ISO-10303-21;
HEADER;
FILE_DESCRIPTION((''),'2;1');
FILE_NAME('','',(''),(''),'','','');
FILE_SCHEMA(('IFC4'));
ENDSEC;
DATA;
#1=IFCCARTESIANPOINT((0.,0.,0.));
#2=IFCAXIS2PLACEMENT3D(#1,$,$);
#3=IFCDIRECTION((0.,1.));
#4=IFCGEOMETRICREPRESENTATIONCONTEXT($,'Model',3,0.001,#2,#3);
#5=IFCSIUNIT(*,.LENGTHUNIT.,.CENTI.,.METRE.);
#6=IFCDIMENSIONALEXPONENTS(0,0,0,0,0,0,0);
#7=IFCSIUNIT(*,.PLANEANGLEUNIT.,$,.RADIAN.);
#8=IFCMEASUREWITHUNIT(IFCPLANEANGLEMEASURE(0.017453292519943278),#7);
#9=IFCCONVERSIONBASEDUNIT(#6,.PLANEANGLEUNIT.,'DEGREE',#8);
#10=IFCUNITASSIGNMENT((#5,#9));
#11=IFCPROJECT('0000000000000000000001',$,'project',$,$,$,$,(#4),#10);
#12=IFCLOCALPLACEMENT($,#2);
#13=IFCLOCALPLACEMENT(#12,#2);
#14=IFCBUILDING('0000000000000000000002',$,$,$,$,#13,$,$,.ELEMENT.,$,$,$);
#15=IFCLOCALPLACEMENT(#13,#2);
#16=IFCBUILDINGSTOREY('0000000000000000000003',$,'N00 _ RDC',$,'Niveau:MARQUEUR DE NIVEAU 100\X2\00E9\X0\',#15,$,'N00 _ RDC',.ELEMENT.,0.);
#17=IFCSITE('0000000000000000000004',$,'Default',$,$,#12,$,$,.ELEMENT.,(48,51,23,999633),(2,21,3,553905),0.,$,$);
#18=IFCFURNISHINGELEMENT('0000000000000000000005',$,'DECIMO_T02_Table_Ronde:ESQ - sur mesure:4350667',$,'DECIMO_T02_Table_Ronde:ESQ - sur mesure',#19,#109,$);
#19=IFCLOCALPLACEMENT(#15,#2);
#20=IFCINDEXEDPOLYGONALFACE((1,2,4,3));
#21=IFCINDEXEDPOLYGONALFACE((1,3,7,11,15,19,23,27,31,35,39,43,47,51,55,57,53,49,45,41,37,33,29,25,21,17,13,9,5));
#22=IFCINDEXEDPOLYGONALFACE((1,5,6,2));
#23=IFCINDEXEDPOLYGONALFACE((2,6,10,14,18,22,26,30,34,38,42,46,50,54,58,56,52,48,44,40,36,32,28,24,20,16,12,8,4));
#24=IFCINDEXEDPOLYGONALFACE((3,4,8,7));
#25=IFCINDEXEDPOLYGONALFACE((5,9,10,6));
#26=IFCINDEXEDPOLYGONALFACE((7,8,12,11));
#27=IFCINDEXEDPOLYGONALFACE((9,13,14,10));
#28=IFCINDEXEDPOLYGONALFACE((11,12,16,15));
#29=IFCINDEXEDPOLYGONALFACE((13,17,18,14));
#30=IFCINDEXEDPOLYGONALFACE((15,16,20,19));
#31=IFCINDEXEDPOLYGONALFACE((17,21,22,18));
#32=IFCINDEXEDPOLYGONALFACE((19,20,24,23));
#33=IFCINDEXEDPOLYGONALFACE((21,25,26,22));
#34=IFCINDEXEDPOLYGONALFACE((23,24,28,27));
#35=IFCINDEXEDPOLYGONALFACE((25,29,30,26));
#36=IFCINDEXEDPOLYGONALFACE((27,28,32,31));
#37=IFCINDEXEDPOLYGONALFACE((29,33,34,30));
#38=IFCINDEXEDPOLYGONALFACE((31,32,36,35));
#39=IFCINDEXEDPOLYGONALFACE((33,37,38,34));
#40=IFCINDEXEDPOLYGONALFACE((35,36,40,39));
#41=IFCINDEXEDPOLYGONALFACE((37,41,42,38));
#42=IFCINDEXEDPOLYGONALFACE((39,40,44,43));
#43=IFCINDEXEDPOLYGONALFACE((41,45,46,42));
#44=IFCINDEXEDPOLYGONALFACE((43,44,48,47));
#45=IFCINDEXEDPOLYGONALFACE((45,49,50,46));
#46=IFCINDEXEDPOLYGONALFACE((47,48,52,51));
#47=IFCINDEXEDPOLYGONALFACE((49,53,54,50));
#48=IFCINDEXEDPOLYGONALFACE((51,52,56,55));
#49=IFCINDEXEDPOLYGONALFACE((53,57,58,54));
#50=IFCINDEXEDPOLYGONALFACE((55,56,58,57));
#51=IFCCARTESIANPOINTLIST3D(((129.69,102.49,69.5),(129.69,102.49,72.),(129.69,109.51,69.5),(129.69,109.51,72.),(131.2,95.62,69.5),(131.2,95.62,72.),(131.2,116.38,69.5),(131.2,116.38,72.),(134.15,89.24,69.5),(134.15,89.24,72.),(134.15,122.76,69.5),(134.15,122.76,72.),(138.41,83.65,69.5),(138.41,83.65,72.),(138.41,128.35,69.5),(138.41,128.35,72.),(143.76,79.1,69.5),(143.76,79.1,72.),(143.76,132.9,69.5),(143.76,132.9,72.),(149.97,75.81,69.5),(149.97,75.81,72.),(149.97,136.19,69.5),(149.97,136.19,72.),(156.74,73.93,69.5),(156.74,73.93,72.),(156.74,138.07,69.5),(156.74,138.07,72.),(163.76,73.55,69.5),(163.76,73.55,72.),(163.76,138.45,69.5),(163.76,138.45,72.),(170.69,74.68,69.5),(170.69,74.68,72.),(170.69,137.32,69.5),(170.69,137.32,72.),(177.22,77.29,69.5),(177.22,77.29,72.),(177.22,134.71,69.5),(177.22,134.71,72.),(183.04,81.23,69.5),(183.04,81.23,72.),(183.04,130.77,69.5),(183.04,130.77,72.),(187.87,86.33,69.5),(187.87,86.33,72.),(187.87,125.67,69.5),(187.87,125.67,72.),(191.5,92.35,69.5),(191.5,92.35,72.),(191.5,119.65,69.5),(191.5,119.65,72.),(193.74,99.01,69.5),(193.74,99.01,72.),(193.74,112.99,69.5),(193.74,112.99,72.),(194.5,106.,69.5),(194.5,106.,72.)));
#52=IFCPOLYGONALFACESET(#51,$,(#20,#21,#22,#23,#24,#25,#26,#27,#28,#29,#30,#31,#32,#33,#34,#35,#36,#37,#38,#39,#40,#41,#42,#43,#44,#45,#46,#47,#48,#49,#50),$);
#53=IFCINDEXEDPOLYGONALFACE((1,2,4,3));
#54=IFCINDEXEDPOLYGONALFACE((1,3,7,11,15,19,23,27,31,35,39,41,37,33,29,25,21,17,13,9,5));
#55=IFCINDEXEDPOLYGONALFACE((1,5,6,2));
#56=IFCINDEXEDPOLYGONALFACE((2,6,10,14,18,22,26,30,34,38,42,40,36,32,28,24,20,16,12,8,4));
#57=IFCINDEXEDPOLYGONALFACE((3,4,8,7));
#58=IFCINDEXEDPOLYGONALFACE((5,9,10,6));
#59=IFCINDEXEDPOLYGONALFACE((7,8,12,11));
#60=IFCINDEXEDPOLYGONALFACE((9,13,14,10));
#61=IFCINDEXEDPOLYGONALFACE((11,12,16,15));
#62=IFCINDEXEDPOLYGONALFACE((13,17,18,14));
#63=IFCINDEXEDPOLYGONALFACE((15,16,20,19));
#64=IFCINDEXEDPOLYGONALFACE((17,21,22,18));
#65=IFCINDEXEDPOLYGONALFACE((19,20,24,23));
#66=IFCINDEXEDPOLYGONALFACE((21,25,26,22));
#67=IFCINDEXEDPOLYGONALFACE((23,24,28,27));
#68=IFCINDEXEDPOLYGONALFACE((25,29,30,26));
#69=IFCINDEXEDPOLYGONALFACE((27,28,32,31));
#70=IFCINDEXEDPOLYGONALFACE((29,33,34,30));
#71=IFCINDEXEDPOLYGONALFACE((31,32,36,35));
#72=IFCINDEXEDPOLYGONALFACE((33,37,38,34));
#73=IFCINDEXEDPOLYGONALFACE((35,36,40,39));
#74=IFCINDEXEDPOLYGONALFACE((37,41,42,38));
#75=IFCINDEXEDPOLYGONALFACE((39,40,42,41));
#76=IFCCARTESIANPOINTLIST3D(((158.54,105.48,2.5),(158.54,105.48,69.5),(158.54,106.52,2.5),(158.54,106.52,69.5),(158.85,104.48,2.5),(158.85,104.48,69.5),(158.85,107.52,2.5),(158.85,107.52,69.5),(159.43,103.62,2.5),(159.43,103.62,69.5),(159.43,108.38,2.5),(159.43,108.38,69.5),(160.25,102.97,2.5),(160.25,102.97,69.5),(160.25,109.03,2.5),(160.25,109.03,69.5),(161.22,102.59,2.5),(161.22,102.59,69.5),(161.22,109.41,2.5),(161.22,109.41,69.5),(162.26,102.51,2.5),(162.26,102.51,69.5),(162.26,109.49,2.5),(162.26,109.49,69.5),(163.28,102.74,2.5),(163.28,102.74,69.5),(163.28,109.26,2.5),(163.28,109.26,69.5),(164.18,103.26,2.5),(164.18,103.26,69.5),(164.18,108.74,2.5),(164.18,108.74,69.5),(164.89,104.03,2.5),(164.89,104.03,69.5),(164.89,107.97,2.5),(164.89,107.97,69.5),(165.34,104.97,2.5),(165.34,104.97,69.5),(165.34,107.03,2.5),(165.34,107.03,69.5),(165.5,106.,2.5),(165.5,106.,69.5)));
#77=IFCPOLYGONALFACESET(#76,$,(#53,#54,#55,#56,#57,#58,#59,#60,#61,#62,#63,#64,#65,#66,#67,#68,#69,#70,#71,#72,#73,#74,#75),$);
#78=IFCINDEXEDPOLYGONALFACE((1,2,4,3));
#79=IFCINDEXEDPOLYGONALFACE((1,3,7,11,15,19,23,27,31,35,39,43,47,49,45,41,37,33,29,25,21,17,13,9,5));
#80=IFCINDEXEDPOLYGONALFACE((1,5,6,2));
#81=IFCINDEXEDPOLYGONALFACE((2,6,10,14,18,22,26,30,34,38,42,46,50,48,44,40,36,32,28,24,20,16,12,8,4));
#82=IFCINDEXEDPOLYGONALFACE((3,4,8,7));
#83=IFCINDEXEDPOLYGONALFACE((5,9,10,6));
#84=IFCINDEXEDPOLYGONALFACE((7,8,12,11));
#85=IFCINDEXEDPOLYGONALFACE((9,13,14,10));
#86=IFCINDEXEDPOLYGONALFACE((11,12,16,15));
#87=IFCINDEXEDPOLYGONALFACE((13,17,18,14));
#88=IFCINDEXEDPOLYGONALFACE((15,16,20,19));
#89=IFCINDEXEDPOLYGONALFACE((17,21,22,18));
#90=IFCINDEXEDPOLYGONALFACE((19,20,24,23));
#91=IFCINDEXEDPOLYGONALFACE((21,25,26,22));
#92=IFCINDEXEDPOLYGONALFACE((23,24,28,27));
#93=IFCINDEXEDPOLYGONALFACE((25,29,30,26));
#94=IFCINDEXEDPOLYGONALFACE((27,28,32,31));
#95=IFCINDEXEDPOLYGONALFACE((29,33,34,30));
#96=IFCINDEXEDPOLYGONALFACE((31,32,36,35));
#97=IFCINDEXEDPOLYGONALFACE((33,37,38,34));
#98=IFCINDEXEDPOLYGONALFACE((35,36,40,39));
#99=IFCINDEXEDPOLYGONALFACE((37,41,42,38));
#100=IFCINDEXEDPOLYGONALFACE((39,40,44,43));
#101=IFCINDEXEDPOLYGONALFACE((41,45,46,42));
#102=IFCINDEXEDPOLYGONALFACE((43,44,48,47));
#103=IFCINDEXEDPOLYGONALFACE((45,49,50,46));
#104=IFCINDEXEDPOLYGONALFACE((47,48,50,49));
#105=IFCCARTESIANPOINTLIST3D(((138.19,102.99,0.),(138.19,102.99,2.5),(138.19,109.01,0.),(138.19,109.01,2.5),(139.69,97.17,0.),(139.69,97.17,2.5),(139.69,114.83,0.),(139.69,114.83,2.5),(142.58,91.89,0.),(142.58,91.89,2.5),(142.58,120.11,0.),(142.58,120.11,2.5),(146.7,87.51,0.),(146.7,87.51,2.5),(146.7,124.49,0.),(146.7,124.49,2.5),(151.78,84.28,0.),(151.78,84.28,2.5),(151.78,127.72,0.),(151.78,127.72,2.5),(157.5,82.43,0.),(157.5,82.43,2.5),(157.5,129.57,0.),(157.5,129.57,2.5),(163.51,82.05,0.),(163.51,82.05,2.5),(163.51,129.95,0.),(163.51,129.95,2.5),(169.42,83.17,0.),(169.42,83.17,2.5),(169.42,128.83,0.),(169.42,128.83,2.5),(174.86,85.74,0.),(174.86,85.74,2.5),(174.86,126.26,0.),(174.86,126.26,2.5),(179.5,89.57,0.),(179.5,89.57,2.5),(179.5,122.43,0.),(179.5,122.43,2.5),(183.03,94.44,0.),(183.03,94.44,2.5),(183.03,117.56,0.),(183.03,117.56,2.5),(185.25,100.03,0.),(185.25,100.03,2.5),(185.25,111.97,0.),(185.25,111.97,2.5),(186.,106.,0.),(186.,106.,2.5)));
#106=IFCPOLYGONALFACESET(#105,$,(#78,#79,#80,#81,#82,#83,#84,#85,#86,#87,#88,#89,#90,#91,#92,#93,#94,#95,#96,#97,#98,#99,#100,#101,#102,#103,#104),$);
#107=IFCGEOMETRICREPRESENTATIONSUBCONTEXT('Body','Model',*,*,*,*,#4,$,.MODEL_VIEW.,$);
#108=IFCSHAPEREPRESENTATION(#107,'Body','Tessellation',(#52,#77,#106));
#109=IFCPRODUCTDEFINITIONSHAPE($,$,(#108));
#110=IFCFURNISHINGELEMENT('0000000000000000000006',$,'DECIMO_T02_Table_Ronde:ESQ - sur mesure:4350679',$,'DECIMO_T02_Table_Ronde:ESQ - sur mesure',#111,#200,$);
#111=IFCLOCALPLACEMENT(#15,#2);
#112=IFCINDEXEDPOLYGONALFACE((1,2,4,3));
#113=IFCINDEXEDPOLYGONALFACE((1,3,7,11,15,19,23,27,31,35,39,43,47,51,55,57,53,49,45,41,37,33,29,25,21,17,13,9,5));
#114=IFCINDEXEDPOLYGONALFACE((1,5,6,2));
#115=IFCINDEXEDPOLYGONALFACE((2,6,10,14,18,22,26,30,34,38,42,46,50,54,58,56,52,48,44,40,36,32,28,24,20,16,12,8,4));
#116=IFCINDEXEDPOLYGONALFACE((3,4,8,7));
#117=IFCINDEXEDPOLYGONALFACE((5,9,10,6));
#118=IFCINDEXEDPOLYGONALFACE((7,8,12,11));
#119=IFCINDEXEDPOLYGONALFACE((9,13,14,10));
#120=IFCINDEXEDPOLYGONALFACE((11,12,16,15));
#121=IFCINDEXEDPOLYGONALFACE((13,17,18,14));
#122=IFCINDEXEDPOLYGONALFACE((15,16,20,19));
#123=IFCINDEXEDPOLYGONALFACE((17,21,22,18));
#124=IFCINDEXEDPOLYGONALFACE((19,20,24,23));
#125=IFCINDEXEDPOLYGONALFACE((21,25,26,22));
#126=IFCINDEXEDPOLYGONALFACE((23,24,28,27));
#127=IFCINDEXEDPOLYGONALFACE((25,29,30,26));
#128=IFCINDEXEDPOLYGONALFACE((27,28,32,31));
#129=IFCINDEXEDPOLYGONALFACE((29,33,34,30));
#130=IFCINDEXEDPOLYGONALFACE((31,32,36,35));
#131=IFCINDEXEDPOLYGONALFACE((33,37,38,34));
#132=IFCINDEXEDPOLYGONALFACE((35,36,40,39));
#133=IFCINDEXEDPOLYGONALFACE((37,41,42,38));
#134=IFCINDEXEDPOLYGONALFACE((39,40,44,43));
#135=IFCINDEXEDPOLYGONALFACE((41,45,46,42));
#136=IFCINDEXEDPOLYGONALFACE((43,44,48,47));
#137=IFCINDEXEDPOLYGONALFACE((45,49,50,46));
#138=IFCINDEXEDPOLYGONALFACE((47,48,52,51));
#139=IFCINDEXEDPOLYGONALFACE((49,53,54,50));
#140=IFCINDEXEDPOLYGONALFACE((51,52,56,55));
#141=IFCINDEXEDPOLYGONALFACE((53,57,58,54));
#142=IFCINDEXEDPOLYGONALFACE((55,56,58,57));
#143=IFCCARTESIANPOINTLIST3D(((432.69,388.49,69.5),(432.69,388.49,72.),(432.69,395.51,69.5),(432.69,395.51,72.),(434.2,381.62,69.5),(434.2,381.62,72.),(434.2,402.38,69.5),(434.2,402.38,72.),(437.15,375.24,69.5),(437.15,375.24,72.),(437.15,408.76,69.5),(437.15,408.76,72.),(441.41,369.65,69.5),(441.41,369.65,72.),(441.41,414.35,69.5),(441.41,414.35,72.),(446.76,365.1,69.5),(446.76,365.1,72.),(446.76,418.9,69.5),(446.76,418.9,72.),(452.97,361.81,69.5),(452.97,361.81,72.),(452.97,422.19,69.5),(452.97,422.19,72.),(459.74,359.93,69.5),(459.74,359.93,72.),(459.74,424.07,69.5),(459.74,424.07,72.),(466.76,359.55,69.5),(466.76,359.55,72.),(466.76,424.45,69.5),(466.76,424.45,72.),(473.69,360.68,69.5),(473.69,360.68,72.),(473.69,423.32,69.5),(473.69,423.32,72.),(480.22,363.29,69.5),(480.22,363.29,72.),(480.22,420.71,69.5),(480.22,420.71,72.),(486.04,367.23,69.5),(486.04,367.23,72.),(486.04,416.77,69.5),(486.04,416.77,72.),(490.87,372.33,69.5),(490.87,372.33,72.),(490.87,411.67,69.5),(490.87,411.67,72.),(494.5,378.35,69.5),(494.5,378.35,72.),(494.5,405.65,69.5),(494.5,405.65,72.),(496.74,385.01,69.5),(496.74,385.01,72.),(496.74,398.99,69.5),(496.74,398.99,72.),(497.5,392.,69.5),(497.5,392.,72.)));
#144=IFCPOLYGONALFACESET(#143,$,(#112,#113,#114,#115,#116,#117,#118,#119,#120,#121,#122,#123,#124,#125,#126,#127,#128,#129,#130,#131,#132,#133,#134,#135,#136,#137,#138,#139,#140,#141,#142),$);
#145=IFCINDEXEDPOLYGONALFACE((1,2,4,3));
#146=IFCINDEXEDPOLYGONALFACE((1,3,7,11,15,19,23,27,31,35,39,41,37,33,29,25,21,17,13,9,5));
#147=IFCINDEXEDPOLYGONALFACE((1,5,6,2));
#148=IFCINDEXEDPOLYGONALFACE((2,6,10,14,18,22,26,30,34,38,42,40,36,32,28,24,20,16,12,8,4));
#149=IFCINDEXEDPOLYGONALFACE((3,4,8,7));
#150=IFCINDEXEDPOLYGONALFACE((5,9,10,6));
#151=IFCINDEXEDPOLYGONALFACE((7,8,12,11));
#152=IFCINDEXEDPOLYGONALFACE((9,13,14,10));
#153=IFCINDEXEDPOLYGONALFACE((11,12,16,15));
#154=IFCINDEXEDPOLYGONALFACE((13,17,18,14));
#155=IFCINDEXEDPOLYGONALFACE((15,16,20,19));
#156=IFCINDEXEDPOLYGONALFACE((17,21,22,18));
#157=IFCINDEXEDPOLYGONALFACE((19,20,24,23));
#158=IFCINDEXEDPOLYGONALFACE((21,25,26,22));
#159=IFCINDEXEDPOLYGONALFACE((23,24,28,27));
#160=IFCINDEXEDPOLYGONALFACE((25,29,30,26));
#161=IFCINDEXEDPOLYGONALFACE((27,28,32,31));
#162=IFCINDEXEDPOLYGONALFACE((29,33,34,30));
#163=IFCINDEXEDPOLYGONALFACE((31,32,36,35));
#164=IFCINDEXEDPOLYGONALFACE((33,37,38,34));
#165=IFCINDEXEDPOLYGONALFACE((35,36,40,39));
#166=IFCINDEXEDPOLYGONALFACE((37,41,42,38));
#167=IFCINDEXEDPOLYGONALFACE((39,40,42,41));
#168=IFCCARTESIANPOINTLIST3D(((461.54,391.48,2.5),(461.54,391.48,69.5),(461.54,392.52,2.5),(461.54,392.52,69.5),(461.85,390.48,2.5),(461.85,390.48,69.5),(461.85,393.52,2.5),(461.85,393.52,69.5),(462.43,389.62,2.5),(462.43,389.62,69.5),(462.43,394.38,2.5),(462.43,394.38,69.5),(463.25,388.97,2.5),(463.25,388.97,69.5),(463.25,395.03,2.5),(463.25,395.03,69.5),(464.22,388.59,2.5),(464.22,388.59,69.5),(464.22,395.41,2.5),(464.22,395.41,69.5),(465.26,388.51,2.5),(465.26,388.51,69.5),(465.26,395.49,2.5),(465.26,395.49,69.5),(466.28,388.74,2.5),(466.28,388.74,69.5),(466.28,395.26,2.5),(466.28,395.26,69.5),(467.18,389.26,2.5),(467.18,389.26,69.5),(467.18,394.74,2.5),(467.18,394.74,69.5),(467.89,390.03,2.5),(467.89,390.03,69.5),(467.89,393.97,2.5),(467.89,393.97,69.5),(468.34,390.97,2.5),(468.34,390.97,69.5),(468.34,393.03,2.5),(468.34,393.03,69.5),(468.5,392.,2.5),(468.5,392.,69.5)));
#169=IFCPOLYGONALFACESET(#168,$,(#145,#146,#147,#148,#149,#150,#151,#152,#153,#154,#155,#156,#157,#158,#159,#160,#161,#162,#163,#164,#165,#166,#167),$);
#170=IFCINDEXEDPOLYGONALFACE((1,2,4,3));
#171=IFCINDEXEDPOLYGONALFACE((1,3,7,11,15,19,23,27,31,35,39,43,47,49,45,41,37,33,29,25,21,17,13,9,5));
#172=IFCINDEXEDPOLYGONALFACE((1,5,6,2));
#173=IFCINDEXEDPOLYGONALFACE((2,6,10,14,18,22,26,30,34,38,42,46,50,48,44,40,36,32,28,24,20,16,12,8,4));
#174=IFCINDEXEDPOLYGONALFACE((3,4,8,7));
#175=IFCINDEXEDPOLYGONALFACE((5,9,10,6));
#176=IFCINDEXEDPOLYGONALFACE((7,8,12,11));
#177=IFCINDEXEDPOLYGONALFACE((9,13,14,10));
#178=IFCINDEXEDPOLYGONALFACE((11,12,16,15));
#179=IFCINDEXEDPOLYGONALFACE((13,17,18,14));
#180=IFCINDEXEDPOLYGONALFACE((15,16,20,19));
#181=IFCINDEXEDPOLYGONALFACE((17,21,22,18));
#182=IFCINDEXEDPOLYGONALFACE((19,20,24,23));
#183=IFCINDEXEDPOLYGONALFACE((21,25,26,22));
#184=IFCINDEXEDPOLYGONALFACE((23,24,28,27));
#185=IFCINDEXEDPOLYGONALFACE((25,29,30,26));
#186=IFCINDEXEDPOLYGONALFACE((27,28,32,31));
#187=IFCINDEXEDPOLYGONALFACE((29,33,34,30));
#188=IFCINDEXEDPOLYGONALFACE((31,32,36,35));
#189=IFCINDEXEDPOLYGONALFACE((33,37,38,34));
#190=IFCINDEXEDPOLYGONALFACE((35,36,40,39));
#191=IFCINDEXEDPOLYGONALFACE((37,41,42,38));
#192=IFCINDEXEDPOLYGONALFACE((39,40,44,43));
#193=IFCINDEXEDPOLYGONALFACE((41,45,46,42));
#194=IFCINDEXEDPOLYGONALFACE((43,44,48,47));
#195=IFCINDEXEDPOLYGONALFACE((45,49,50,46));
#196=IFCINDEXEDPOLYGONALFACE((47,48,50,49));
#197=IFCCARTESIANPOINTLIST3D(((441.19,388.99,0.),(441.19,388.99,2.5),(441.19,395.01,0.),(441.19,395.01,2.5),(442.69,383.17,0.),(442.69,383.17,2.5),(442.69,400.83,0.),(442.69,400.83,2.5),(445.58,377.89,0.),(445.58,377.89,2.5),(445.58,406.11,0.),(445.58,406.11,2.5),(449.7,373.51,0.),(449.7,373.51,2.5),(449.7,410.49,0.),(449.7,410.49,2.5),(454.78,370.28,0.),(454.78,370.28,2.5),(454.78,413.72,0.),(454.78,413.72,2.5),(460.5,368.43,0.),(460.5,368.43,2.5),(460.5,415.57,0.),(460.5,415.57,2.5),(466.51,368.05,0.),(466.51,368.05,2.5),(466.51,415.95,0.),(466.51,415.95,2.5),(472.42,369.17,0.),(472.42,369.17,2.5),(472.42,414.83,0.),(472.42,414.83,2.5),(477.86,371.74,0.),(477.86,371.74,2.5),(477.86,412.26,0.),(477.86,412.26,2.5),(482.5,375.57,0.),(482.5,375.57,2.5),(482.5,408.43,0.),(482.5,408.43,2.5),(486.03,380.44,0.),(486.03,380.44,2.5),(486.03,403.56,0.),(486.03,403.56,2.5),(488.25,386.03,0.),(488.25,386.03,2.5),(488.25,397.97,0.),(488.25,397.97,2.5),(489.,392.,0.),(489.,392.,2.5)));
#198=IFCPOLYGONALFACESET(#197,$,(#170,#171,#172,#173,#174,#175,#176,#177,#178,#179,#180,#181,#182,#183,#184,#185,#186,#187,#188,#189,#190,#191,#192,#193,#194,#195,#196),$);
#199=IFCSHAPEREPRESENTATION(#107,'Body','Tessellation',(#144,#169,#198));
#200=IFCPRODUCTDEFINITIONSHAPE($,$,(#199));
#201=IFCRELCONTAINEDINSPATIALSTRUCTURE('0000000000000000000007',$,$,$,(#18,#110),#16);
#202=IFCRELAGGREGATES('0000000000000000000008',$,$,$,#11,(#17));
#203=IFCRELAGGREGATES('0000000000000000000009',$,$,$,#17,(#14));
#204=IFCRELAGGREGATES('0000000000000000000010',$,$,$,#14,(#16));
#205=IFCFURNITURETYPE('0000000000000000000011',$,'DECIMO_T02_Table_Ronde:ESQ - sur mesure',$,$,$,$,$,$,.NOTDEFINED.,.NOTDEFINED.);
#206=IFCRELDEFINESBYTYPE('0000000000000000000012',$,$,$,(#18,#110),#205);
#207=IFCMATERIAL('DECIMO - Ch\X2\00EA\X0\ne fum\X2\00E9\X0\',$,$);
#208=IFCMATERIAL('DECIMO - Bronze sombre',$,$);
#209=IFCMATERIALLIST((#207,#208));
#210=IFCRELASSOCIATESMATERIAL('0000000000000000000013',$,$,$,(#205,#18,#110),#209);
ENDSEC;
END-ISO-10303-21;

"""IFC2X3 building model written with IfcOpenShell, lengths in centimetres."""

from ifc_helpers import new_model, entity, si_unit, converted_unit, direction, frame, frame_2d, origin, place, context, subcontext, project, spatial, circle, extrude, source, transform, mapped, material, material_list, type_object, type_shapes, element, save


model = new_model("IFC2X3")

# Units and contexts
model_context = context("Model", 3, precision=0.001, world=origin(), true_north=direction((0.0, 1.0)))
body_context = subcontext(model_context, "Body", "Model", "MODEL_VIEW")
ifc_project = project(units=[si_unit("LENGTHUNIT", "METRE", prefix="CENTI"), converted_unit("PLANEANGLEUNIT", "DEGREE", entity("IfcPlaneAngleMeasure", 0.017453292519943278), si_unit("PLANEANGLEUNIT", "RADIAN"), dimensions=[0, 0, 0, 0, 0, 0, 0])], contexts=[model_context])

# Site, building, storey
site_placement = place(None, origin())
site = spatial("IfcSite", under=ifc_project, at=site_placement, Name="Default", CompositionType="ELEMENT", RefLatitude=(48, 51, 23, 999633), RefLongitude=(2, 21, 3, 553905), RefElevation=0.0)
building_placement = place(site_placement, origin())
building = spatial("IfcBuilding", under=site, at=building_placement, CompositionType="ELEMENT")
storey_placement = place(building_placement, origin())
storey = spatial("IfcBuildingStorey", under=building, at=storey_placement, Name="N00 _ RDC", ObjectType="Niveau:MARQUEUR DE NIVEAU 100é", LongName="N00 _ RDC", CompositionType="ELEMENT", Elevation=0.0)

# Furnishing elements
ifc_material_1 = material(Name="DECIMO - Bronze sombre")
ifc_material_2 = material(Name="DECIMO - Chêne fumé")
ifc_material_list_1 = material_list([ifc_material_2, ifc_material_1])
furniture_type_1 = type_object("IfcFurnitureType", Name="DECIMO_T02_Table_Ronde:ESQ - sur mesure", AssemblyPlace="NOTDEFINED", material=ifc_material_list_1)
shared_shape_1 = source(origin(), body_context, "Body", "SweptSolid", [
    extrude(circle(Radius=32.5, at=frame_2d((0.0, 0.0), x_axis=(1.0, 0.0))), frame((0.0, 0.0, 69.5)), (0.0, 0.0, 1.0), 2.5),
    extrude(circle(Radius=3.5, at=frame_2d((0.0, 0.0), x_axis=(1.0, 0.0))), frame((0.0, 0.0, 2.5)), (0.0, 0.0, 1.0), 67.0),
    extrude(circle(Radius=24.0, at=frame_2d((0.0, 0.0), x_axis=(1.0, 0.0))), origin(), (0.0, 0.0, 1.0), 2.5),
])
type_shapes(furniture_type_1, [shared_shape_1])
for number, where, name in (
    (1, (162.0, 106.0, 0.0), "DECIMO_T02_Table_Ronde:ESQ - sur mesure:4350667"),
    (2, (465.0, 392.0, 0.0), "DECIMO_T02_Table_Ronde:ESQ - sur mesure:4350679"),
):
    element("IfcFurnishingElement", number, at=place(storey_placement, frame(where)), inside=storey, type_object=furniture_type_1, material=ifc_material_list_1, Name=name, ObjectType="DECIMO_T02_Table_Ronde:ESQ - sur mesure", context=body_context, shape_type="MappedRepresentation", body=[
        mapped(shared_shape_1, transform((0.0, 0.0, 0.0), scale=1.0)),
    ])

save(model, "model.ifc")
